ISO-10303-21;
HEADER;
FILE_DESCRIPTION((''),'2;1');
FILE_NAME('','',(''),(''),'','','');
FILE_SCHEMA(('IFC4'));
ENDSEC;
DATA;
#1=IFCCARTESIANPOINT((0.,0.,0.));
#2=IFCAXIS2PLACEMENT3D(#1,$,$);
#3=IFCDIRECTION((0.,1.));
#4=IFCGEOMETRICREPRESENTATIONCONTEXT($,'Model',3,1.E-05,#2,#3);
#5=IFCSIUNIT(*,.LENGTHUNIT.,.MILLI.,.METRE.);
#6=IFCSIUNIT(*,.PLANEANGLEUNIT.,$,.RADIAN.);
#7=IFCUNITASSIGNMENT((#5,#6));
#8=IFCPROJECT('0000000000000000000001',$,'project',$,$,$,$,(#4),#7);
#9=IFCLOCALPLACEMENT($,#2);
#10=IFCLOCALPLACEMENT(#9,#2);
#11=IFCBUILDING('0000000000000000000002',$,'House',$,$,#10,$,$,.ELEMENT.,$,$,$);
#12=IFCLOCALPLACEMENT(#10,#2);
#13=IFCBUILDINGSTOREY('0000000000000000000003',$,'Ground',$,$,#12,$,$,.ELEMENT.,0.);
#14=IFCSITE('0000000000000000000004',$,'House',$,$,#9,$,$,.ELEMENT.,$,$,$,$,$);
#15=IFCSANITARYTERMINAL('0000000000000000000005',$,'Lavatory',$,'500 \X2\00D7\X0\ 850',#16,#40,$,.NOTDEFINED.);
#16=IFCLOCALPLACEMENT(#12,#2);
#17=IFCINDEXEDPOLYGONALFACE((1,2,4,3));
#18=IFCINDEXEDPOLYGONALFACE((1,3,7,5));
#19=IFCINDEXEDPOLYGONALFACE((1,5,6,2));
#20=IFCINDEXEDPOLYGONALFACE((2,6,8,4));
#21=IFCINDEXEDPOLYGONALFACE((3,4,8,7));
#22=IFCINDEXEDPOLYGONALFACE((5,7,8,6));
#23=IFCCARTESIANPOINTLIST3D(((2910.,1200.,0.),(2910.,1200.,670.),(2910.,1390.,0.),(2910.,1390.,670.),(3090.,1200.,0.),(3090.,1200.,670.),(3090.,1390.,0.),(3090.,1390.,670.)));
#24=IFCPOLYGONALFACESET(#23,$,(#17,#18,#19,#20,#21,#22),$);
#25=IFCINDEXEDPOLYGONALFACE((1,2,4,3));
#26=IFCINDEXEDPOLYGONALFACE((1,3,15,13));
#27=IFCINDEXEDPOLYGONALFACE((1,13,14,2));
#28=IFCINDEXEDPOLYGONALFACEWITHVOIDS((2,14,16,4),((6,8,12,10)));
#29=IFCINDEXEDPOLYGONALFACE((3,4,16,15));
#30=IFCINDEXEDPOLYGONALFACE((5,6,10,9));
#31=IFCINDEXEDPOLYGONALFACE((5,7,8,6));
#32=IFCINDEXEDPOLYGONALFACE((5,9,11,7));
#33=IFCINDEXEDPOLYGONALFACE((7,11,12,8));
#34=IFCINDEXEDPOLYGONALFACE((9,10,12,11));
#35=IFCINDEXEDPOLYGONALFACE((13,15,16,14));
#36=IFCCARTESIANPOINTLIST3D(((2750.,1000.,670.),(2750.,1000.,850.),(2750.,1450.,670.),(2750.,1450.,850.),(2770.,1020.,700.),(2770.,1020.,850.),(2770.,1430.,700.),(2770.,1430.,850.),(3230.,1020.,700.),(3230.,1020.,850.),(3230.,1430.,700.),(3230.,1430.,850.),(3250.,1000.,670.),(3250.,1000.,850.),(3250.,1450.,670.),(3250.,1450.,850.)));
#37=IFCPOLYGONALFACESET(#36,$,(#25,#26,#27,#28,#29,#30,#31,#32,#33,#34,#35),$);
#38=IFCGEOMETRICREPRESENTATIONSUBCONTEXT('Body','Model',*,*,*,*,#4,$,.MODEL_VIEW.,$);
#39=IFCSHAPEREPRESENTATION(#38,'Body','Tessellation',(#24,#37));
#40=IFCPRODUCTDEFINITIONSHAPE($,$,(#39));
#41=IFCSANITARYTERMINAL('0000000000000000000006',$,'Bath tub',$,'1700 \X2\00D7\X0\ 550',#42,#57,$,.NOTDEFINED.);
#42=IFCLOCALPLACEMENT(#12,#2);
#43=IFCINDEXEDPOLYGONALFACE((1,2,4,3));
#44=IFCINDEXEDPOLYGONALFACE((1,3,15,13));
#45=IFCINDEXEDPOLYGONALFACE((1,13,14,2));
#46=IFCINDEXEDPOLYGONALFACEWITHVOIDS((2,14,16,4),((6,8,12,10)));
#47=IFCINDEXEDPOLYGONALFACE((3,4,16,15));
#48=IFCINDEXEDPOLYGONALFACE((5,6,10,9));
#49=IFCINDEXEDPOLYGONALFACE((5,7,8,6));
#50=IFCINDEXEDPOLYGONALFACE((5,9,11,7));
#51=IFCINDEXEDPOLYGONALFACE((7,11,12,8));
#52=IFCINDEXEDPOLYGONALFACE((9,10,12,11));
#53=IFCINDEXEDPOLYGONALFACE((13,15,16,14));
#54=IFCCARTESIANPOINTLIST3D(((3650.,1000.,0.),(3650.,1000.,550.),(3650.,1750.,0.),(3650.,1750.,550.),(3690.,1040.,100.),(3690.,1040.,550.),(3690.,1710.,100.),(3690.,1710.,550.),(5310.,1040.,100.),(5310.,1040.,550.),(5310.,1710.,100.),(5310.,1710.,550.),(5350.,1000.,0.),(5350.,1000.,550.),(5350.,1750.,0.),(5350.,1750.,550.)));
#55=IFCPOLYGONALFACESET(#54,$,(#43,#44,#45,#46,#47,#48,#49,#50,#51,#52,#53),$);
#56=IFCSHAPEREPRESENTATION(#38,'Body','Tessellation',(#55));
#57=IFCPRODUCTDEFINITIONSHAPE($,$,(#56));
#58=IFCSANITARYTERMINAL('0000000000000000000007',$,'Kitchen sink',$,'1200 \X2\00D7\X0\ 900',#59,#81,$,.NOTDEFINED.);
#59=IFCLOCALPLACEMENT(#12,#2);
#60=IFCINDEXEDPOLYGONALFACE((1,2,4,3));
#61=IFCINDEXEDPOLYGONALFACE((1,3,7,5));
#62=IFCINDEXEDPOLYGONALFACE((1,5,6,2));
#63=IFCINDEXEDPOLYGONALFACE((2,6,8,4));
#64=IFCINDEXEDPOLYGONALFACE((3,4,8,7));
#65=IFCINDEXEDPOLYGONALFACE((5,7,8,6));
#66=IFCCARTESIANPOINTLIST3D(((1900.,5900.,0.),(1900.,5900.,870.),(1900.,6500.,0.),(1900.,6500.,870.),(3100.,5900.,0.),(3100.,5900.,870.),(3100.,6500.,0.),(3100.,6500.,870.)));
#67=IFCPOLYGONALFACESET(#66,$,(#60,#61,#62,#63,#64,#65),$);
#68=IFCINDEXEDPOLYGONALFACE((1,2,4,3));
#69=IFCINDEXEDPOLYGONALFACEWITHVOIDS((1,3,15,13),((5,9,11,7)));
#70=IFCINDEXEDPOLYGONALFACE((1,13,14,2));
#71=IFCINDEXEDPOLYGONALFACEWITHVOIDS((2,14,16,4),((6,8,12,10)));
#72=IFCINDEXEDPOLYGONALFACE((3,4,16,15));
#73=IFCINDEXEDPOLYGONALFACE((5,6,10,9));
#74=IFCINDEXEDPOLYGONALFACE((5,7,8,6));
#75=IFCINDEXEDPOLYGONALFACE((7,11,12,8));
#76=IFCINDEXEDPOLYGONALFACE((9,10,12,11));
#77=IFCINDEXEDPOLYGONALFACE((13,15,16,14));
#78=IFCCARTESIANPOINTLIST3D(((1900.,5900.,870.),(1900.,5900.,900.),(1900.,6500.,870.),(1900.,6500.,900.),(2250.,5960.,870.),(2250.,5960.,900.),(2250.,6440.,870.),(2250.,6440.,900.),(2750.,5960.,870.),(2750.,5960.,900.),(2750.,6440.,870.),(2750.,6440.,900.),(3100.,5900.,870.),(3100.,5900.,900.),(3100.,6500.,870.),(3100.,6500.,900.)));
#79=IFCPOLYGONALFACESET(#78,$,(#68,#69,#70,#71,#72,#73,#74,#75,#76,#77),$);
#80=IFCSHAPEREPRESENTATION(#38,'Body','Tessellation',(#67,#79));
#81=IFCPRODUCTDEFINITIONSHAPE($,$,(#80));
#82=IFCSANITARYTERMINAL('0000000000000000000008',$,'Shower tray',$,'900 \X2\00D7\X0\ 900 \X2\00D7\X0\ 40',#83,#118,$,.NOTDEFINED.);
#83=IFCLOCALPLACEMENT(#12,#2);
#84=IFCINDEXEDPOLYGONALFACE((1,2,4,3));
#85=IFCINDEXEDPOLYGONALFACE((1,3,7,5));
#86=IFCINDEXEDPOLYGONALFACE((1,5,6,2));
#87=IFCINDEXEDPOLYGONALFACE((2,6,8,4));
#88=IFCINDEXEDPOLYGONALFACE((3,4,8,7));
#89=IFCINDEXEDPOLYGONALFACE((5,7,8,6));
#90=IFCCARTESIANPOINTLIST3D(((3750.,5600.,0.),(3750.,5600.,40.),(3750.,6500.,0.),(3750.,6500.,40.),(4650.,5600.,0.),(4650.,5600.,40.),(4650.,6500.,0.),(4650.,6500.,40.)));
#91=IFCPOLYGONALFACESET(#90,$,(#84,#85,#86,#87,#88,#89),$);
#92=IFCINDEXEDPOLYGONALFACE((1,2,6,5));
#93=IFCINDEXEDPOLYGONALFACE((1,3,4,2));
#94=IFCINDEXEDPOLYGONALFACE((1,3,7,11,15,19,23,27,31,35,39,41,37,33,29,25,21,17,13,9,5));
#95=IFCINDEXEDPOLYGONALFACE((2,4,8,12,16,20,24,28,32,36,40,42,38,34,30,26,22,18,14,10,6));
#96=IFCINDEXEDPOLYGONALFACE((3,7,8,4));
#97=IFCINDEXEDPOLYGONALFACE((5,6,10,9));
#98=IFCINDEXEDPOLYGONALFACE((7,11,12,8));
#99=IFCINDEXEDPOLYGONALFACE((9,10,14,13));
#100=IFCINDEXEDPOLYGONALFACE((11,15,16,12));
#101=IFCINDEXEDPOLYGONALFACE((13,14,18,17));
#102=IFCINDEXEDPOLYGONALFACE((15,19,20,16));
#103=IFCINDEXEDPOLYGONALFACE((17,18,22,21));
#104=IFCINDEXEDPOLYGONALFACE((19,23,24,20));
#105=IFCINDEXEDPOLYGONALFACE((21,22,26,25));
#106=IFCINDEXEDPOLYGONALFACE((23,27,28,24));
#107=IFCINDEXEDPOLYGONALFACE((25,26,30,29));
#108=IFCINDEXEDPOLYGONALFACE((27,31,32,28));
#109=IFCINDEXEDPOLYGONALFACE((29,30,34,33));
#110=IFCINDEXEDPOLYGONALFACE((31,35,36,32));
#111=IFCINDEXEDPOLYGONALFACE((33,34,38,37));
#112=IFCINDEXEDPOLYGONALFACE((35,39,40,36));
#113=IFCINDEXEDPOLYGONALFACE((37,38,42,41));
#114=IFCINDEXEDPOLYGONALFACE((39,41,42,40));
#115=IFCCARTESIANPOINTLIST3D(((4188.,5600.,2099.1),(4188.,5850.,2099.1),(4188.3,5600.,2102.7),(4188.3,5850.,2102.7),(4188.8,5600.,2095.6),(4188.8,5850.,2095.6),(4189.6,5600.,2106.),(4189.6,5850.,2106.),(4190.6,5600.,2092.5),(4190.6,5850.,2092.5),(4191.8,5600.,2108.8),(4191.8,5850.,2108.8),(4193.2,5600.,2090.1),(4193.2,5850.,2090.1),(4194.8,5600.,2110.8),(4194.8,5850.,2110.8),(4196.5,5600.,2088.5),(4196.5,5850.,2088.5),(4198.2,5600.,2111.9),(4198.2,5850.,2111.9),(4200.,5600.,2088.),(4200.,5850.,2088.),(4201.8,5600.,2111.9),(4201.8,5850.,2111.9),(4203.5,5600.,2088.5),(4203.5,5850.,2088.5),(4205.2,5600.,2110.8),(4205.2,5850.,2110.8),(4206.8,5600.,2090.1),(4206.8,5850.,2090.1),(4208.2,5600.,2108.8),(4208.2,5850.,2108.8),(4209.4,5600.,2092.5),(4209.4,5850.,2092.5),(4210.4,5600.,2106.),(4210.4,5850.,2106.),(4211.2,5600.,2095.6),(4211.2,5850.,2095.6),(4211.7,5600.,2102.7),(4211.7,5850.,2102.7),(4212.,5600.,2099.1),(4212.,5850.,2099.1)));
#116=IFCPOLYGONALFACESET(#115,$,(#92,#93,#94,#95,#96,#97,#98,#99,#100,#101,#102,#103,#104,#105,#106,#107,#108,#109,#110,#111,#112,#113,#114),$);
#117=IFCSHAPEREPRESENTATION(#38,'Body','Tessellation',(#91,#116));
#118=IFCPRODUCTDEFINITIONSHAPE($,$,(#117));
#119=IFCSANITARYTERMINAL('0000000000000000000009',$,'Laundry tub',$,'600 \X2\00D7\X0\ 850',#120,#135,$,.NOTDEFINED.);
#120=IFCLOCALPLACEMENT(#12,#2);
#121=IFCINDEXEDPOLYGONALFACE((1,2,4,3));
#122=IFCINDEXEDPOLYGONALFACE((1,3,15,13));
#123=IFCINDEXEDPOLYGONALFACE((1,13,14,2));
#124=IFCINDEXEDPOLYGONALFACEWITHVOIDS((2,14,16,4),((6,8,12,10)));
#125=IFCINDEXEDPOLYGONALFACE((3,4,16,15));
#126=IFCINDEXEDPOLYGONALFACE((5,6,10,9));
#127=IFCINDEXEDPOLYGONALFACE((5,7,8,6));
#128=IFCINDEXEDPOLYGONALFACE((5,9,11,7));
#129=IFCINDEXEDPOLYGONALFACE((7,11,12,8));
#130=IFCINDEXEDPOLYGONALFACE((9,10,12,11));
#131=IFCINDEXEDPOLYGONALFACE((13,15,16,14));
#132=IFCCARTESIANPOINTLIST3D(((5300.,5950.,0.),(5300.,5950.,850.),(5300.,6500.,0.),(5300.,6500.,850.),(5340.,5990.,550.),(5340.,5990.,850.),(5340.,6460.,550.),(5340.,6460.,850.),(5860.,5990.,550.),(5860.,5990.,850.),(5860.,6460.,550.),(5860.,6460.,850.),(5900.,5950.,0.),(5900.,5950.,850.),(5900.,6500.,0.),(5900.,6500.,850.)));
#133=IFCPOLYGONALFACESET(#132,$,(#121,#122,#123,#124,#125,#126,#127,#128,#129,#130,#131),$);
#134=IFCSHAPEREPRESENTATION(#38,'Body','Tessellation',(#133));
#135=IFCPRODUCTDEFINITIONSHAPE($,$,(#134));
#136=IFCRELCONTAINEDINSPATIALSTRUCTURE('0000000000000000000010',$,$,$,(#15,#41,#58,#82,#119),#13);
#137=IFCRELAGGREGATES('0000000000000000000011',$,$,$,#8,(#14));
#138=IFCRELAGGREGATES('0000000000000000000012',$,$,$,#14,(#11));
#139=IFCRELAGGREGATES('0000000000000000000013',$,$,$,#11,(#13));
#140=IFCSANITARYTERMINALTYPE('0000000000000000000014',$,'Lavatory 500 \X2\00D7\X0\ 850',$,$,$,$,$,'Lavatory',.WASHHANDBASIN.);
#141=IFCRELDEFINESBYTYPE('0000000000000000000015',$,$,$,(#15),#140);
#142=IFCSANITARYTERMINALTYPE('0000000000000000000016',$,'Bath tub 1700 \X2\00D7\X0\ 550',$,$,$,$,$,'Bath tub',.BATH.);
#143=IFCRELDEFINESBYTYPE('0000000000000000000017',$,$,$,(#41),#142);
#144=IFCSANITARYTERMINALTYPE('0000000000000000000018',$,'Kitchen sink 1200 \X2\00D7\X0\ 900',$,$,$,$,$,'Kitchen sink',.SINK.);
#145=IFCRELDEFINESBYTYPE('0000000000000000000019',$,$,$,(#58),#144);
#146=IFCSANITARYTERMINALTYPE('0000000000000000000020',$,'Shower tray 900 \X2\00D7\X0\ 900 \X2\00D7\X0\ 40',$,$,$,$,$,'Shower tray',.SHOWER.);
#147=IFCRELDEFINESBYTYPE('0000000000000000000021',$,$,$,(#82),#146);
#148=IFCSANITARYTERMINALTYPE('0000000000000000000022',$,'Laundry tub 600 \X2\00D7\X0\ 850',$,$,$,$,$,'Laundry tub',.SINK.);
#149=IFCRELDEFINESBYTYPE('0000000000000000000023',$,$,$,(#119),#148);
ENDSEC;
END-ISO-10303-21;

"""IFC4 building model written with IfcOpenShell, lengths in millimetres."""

from ifc_helpers import new_model, entity, si_unit, direction, frame, origin, place, context, subcontext, project, spatial, polyline, outline, extrude, source, transform, mapped, type_object, type_shapes, element, save


model = new_model("IFC4")

# Units and contexts
model_context = context("Model", 3, precision=1e-05, world=origin(), true_north=direction((0.0, 1.0)))
body_context = subcontext(model_context, "Body", "Model", "MODEL_VIEW")
ifc_project = project(units=[si_unit("LENGTHUNIT", "METRE", prefix="MILLI"), si_unit("PLANEANGLEUNIT", "RADIAN")], contexts=[model_context])

# Site, building, storey
site_placement = place(None, origin())
site = spatial("IfcSite", under=ifc_project, at=site_placement, Name="House", CompositionType="ELEMENT")
building_placement = place(site_placement, origin())
building = spatial("IfcBuilding", under=site, at=building_placement, Name="House", CompositionType="ELEMENT")
storey_placement = place(building_placement, origin())
storey = spatial("IfcBuildingStorey", under=building, at=storey_placement, Name="Ground", CompositionType="ELEMENT", Elevation=0.0)

# Sanitary terminals
sanitary_terminal_type_1 = type_object("IfcSanitaryTerminalType", Name="Lavatory 500 × 850", ElementType="Lavatory", PredefinedType="WASHHANDBASIN")
cartesian_point_1 = entity("IfcCartesianPoint", [-250.0, 0.0])
cartesian_point_2 = entity("IfcCartesianPoint", [-230.0, 20.0])
shared_shape_1 = source(origin(), body_context, "Body", "SolidModel", [
    extrude(outline(polyline([(-90.0, 200.0), (90.0, 200.0), (90.0, 390.0), (-90.0, 390.0), (-90.0, 200.0)])), origin(), (0.0, 0.0, 1.0), 670.0),
    entity("IfcCsgSolid", entity("IfcBooleanResult", "DIFFERENCE", entity("IfcExtrudedAreaSolid", entity("IfcArbitraryClosedProfileDef", "AREA", None, entity("IfcPolyline", [cartesian_point_1, entity("IfcCartesianPoint", [250.0, 0.0]), entity("IfcCartesianPoint", [250.0, 450.0]), entity("IfcCartesianPoint", [-250.0, 450.0]), cartesian_point_1])), entity("IfcAxis2Placement3D", entity("IfcCartesianPoint", [0.0, 0.0, 670.0])), entity("IfcDirection", [0.0, 0.0, 1.0]), 180.0), entity("IfcExtrudedAreaSolid", entity("IfcArbitraryClosedProfileDef", "AREA", None, entity("IfcPolyline", [cartesian_point_2, entity("IfcCartesianPoint", [230.0, 20.0]), entity("IfcCartesianPoint", [230.0, 430.0]), entity("IfcCartesianPoint", [-230.0, 430.0]), cartesian_point_2])), entity("IfcAxis2Placement3D", entity("IfcCartesianPoint", [0.0, 0.0, 700.0])), entity("IfcDirection", [0.0, 0.0, 1.0]), 151.0))),
])
type_shapes(sanitary_terminal_type_1, [shared_shape_1])
sanitary_terminal_1_placement = place(storey_placement, frame((3000.0, 1000.0, 0.0), z_axis=(0.0, 0.0, 1.0), x_axis=(1.0, 0.0, 0.0)))
element("IfcSanitaryTerminal", 1, at=sanitary_terminal_1_placement, inside=storey, type_object=sanitary_terminal_type_1, Name="Lavatory", ObjectType="500 × 850", PredefinedType="NOTDEFINED", context=body_context, shape_type="MappedRepresentation", body=[
    mapped(shared_shape_1, transform((0.0, 0.0, 0.0))),
])
sanitary_terminal_type_2 = type_object("IfcSanitaryTerminalType", Name="Bath tub 1700 × 550", ElementType="Bath tub", PredefinedType="BATH")
cartesian_point_3 = entity("IfcCartesianPoint", [-850.0, 0.0])
cartesian_point_4 = entity("IfcCartesianPoint", [-810.0, 40.0])
shared_shape_2 = source(origin(), body_context, "Body", "SolidModel", [
    entity("IfcCsgSolid", entity("IfcBooleanResult", "DIFFERENCE", entity("IfcExtrudedAreaSolid", entity("IfcArbitraryClosedProfileDef", "AREA", None, entity("IfcPolyline", [cartesian_point_3, entity("IfcCartesianPoint", [850.0, 0.0]), entity("IfcCartesianPoint", [850.0, 750.0]), entity("IfcCartesianPoint", [-850.0, 750.0]), cartesian_point_3])), entity("IfcAxis2Placement3D", entity("IfcCartesianPoint", [0.0, 0.0, 0.0])), entity("IfcDirection", [0.0, 0.0, 1.0]), 550.0), entity("IfcExtrudedAreaSolid", entity("IfcArbitraryClosedProfileDef", "AREA", None, entity("IfcPolyline", [cartesian_point_4, entity("IfcCartesianPoint", [810.0, 40.0]), entity("IfcCartesianPoint", [810.0, 710.0]), entity("IfcCartesianPoint", [-810.0, 710.0]), cartesian_point_4])), entity("IfcAxis2Placement3D", entity("IfcCartesianPoint", [0.0, 0.0, 100.0])), entity("IfcDirection", [0.0, 0.0, 1.0]), 451.0))),
])
type_shapes(sanitary_terminal_type_2, [shared_shape_2])
sanitary_terminal_2_placement = place(storey_placement, frame((4500.0, 1000.0, 0.0), z_axis=(0.0, 0.0, 1.0), x_axis=(1.0, 0.0, 0.0)))
element("IfcSanitaryTerminal", 2, at=sanitary_terminal_2_placement, inside=storey, type_object=sanitary_terminal_type_2, Name="Bath tub", ObjectType="1700 × 550", PredefinedType="NOTDEFINED", context=body_context, shape_type="MappedRepresentation", body=[
    mapped(shared_shape_2, transform((0.0, 0.0, 0.0))),
])
sanitary_terminal_type_3 = type_object("IfcSanitaryTerminalType", Name="Kitchen sink 1200 × 900", ElementType="Kitchen sink", PredefinedType="SINK")
cartesian_point_5 = entity("IfcCartesianPoint", [-600.0, 0.0])
cartesian_point_6 = entity("IfcCartesianPoint", [-250.0, 60.0])
shared_shape_3 = source(origin(), body_context, "Body", "SolidModel", [
    extrude(outline(polyline([(-600.0, 0.0), (600.0, 0.0), (600.0, 600.0), (-600.0, 600.0), (-600.0, 0.0)])), origin(), (0.0, 0.0, 1.0), 870.0),
    entity("IfcCsgSolid", entity("IfcBooleanResult", "DIFFERENCE", entity("IfcExtrudedAreaSolid", entity("IfcArbitraryClosedProfileDef", "AREA", None, entity("IfcPolyline", [cartesian_point_5, entity("IfcCartesianPoint", [600.0, 0.0]), entity("IfcCartesianPoint", [600.0, 600.0]), entity("IfcCartesianPoint", [-600.0, 600.0]), cartesian_point_5])), entity("IfcAxis2Placement3D", entity("IfcCartesianPoint", [0.0, 0.0, 870.0])), entity("IfcDirection", [0.0, 0.0, 1.0]), 30.0), entity("IfcExtrudedAreaSolid", entity("IfcArbitraryClosedProfileDef", "AREA", None, entity("IfcPolyline", [cartesian_point_6, entity("IfcCartesianPoint", [250.0, 60.0]), entity("IfcCartesianPoint", [250.0, 540.0]), entity("IfcCartesianPoint", [-250.0, 540.0]), cartesian_point_6])), entity("IfcAxis2Placement3D", entity("IfcCartesianPoint", [0.0, 0.0, 720.0])), entity("IfcDirection", [0.0, 0.0, 1.0]), 181.0))),
])
type_shapes(sanitary_terminal_type_3, [shared_shape_3])
sanitary_terminal_3_placement = place(storey_placement, frame((2500.0, 6500.0, 0.0), z_axis=(0.0, 0.0, 1.0), x_axis=(-1.0, 0.0, 0.0)))
element("IfcSanitaryTerminal", 3, at=sanitary_terminal_3_placement, inside=storey, type_object=sanitary_terminal_type_3, Name="Kitchen sink", ObjectType="1200 × 900", PredefinedType="NOTDEFINED", context=body_context, shape_type="MappedRepresentation", body=[
    mapped(shared_shape_3, transform((0.0, 0.0, 0.0))),
])
sanitary_terminal_type_4 = type_object("IfcSanitaryTerminalType", Name="Shower tray 900 × 900 × 40", ElementType="Shower tray", PredefinedType="SHOWER")
shared_shape_4 = source(origin(), body_context, "Body", "AdvancedSweptSolid", [
    extrude(outline(polyline([(-450.0, 0.0), (450.0, 0.0), (450.0, 900.0), (-450.0, 900.0), (-450.0, 0.0)])), origin(), (0.0, 0.0, 1.0), 40.0),
    entity("IfcSweptDiskSolid", entity("IfcPolyline", [entity("IfcCartesianPoint", [0.0, 900.0, 2100.0]), entity("IfcCartesianPoint", [0.0, 650.0, 2100.0])]), 12.0),
])
type_shapes(sanitary_terminal_type_4, [shared_shape_4])
sanitary_terminal_4_placement = place(storey_placement, frame((4200.0, 6500.0, 0.0), z_axis=(0.0, 0.0, 1.0), x_axis=(-1.0, 0.0, 0.0)))
element("IfcSanitaryTerminal", 4, at=sanitary_terminal_4_placement, inside=storey, type_object=sanitary_terminal_type_4, Name="Shower tray", ObjectType="900 × 900 × 40", PredefinedType="NOTDEFINED", context=body_context, shape_type="MappedRepresentation", body=[
    mapped(shared_shape_4, transform((0.0, 0.0, 0.0))),
])
sanitary_terminal_type_5 = type_object("IfcSanitaryTerminalType", Name="Laundry tub 600 × 850", ElementType="Laundry tub", PredefinedType="SINK")
cartesian_point_7 = entity("IfcCartesianPoint", [-300.0, 0.0])
cartesian_point_8 = entity("IfcCartesianPoint", [-260.0, 40.0])
shared_shape_5 = source(origin(), body_context, "Body", "SolidModel", [
    entity("IfcCsgSolid", entity("IfcBooleanResult", "DIFFERENCE", entity("IfcExtrudedAreaSolid", entity("IfcArbitraryClosedProfileDef", "AREA", None, entity("IfcPolyline", [cartesian_point_7, entity("IfcCartesianPoint", [300.0, 0.0]), entity("IfcCartesianPoint", [300.0, 550.0]), entity("IfcCartesianPoint", [-300.0, 550.0]), cartesian_point_7])), entity("IfcAxis2Placement3D", entity("IfcCartesianPoint", [0.0, 0.0, 0.0])), entity("IfcDirection", [0.0, 0.0, 1.0]), 850.0), entity("IfcExtrudedAreaSolid", entity("IfcArbitraryClosedProfileDef", "AREA", None, entity("IfcPolyline", [cartesian_point_8, entity("IfcCartesianPoint", [260.0, 40.0]), entity("IfcCartesianPoint", [260.0, 510.0]), entity("IfcCartesianPoint", [-260.0, 510.0]), cartesian_point_8])), entity("IfcAxis2Placement3D", entity("IfcCartesianPoint", [0.0, 0.0, 550.0])), entity("IfcDirection", [0.0, 0.0, 1.0]), 301.0))),
])
type_shapes(sanitary_terminal_type_5, [shared_shape_5])
sanitary_terminal_5_placement = place(storey_placement, frame((5600.0, 6500.0, 0.0), z_axis=(0.0, 0.0, 1.0), x_axis=(-1.0, 0.0, 0.0)))
element("IfcSanitaryTerminal", 5, at=sanitary_terminal_5_placement, inside=storey, type_object=sanitary_terminal_type_5, Name="Laundry tub", ObjectType="600 × 850", PredefinedType="NOTDEFINED", context=body_context, shape_type="MappedRepresentation", body=[
    mapped(shared_shape_5, transform((0.0, 0.0, 0.0))),
])

save(model, "model.ifc")
